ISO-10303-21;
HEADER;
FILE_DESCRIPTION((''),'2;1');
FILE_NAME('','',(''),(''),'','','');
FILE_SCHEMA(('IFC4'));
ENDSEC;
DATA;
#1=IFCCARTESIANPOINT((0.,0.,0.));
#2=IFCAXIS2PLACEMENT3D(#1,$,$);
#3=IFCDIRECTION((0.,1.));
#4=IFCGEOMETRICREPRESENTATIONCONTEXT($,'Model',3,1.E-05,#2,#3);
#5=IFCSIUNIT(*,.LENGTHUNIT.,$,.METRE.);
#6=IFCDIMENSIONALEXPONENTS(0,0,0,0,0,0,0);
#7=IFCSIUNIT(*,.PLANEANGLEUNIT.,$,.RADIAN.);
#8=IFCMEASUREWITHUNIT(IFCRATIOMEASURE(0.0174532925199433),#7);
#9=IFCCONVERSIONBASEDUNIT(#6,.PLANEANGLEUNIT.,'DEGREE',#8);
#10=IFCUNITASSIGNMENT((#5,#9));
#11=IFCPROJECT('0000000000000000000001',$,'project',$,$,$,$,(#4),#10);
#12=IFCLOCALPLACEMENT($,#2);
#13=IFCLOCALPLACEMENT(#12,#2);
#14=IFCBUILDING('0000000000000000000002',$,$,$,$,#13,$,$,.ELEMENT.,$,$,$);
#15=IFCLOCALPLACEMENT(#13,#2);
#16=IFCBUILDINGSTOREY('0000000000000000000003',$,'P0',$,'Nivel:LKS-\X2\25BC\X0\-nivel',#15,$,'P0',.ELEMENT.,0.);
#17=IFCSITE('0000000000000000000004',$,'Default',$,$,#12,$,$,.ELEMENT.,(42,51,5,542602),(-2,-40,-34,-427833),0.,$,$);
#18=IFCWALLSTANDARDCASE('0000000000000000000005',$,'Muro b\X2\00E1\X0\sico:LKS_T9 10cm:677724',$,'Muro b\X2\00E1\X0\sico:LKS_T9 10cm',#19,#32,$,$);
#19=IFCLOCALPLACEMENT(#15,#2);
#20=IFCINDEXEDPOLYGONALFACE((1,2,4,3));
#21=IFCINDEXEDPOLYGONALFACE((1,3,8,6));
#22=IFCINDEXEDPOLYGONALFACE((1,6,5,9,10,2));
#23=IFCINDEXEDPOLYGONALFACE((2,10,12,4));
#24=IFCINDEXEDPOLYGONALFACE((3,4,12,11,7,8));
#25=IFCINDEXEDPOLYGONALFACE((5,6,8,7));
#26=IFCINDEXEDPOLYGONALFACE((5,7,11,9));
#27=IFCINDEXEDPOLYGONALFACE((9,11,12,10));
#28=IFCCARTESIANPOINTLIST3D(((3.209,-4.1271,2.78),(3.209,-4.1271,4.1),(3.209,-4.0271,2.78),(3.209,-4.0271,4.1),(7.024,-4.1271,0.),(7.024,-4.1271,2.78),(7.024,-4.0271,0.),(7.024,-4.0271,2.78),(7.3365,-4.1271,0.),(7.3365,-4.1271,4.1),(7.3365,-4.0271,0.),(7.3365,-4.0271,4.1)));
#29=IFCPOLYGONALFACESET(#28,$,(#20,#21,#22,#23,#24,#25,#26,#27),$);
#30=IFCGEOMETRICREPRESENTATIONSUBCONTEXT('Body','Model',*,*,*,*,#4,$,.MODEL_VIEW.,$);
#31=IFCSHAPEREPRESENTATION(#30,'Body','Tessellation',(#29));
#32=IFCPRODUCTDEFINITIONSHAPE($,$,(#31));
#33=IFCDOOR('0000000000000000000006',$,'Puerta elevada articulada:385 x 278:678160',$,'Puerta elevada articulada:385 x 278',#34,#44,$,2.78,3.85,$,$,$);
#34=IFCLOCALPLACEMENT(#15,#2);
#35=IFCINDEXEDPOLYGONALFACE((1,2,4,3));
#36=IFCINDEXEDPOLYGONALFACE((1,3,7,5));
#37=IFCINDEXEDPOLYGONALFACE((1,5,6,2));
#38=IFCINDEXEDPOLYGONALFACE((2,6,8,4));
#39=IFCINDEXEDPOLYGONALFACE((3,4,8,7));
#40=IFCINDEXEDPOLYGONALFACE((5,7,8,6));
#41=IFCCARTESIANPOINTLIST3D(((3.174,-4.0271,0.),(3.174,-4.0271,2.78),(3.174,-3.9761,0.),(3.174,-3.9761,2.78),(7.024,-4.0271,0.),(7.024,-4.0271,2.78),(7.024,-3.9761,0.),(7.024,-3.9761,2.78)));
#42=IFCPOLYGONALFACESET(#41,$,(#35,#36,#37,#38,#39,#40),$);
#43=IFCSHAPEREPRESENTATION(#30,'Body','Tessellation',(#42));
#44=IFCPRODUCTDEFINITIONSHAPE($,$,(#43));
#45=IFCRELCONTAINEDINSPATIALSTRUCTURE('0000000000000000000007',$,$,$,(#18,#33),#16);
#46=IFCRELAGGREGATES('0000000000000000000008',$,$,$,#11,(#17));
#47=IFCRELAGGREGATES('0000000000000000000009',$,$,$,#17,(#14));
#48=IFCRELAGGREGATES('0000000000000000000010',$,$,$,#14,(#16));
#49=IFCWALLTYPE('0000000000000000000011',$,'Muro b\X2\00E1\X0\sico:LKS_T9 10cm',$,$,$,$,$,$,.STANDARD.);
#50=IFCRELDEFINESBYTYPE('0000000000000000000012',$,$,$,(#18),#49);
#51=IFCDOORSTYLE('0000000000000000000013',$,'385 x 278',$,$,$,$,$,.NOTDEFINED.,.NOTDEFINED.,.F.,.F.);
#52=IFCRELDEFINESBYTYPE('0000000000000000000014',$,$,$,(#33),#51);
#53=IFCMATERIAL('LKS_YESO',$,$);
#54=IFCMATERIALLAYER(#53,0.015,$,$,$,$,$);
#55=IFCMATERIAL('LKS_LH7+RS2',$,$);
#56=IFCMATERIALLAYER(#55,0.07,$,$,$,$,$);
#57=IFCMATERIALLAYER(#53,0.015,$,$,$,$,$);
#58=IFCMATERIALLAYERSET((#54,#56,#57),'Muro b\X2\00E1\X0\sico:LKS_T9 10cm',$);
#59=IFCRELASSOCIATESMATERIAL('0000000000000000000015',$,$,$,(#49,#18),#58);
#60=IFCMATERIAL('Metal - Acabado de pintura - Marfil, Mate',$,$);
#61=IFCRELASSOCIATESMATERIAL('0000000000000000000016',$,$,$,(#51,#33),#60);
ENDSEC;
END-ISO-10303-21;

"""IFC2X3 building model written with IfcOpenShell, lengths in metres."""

from ifc_helpers import new_model, entity, si_unit, converted_unit, direction, frame, frame_2d, origin, place, context, subcontext, project, spatial, rectangle, extrude, source, transform, mapped, material, layer, layer_set, layer_usage, type_object, type_shapes, element, fill, save


model = new_model("IFC2X3")

# Units and contexts
model_context = context("Model", 3, precision=1e-05, world=origin(), true_north=direction((0.0, 1.0)))
body_context = subcontext(model_context, "Body", "Model", "MODEL_VIEW")
ifc_project = project(units=[si_unit("LENGTHUNIT", "METRE"), converted_unit("PLANEANGLEUNIT", "DEGREE", entity("IfcRatioMeasure", 0.0174532925199433), si_unit("PLANEANGLEUNIT", "RADIAN"), dimensions=[0, 0, 0, 0, 0, 0, 0])], contexts=[model_context])

# Site, building, storey
site_placement = place(None, origin())
site = spatial("IfcSite", under=ifc_project, at=site_placement, Name="Default", CompositionType="ELEMENT", RefLatitude=(42, 51, 5, 542602), RefLongitude=(-2, -40, -34, -427833), RefElevation=0.0)
building_placement = place(site_placement, origin())
building = spatial("IfcBuilding", under=site, at=building_placement, CompositionType="ELEMENT")
storey_placement = place(building_placement, origin())
storey = spatial("IfcBuildingStorey", under=building, at=storey_placement, Name="P0", ObjectType="Nivel:LKS-▼-nivel", LongName="P0", CompositionType="ELEMENT", Elevation=0.0)

# Wall, opening, door
ifc_material_1 = material(Name="LKS_YESO")
ifc_layer_1 = layer(ifc_material_1, 0.015)
ifc_material_2 = material(Name="LKS_LH7+RS2")
ifc_layer_2 = layer(ifc_material_2, 0.07)
ifc_layer_3 = layer(ifc_material_1, 0.015)
ifc_layer_set_1 = layer_set([ifc_layer_1, ifc_layer_2, ifc_layer_3], Name="Muro básico:LKS_T9 10cm")
ifc_layer_usage_1 = layer_usage(ifc_layer_set_1, "AXIS2", "NEGATIVE", 0.05)
wall_type = type_object("IfcWallType", Name="Muro básico:LKS_T9 10cm", PredefinedType="STANDARD", material=ifc_layer_set_1)
wall_placement = place(storey_placement, frame((3.209, -4.0771, 0.0)))
wall = element("IfcWallStandardCase", 1, at=wall_placement, inside=storey, type_object=wall_type, material=ifc_layer_usage_1, Name="Muro básico:LKS_T9 10cm:677724", ObjectType="Muro básico:LKS_T9 10cm", context=body_context, shape_type="SweptSolid", body=[
    extrude(rectangle(XDim=4.1276, YDim=0.1, at=frame_2d((2.0638, 0.0), x_axis=(-1.0, 0.0))), origin(), (0.0, 0.0, 1.0), 4.1),
])
opening_placement = place(wall_placement, frame((-0.035, -0.05, 0.0)))
opening = element("IfcOpeningElement", 2, at=opening_placement, cuts=wall, ObjectType="Opening", context=body_context, shape_type="SweptSolid", body=[
    extrude(rectangle(XDim=2.78, YDim=3.85, at=frame_2d((1.39, 1.925), x_axis=(1.0, 0.0))), frame((0.0, 0.0, 0.0), z_axis=(0.0, 1.0, 0.0), x_axis=(0.0, 0.0, 1.0)), (0.0, 0.0, 1.0), 0.1),
])
ifc_material_3 = material(Name="Metal - Acabado de pintura - Marfil, Mate")
door_style = type_object("IfcDoorStyle", Name="385 x 278", ConstructionType="NOTDEFINED", OperationType="NOTDEFINED", ParameterTakesPrecedence=False, Sizeable=False, material=ifc_material_3)
shared_shape_1 = source(origin(), body_context, "Body", "SweptSolid", [
    extrude(rectangle(XDim=3.85, YDim=0.051, at=frame_2d((0.0, 0.0), x_axis=(1.0, 0.0))), frame((1.925, -0.0255, 0.0), z_axis=(0.0, 0.0, 1.0), x_axis=(-1.0, 0.0, 0.0)), (0.0, 0.0, 1.0), 2.78),
])
type_shapes(door_style, [shared_shape_1])
door_placement = place(opening_placement, frame((3.85, 0.1, 0.0), z_axis=(0.0, 0.0, 1.0), x_axis=(-1.0, 0.0, 0.0)))
door = element("IfcDoor", 3, at=door_placement, inside=storey, type_object=door_style, material=ifc_material_3, Name="Puerta elevada articulada:385 x 278:678160", ObjectType="Puerta elevada articulada:385 x 278", OverallHeight=2.78, OverallWidth=3.85, context=body_context, shape_type="MappedRepresentation", body=[
    mapped(shared_shape_1, transform((0.0, 0.0, 0.0), scale=1.0)),
])
fill(opening, door)

save(model, "model.ifc")
